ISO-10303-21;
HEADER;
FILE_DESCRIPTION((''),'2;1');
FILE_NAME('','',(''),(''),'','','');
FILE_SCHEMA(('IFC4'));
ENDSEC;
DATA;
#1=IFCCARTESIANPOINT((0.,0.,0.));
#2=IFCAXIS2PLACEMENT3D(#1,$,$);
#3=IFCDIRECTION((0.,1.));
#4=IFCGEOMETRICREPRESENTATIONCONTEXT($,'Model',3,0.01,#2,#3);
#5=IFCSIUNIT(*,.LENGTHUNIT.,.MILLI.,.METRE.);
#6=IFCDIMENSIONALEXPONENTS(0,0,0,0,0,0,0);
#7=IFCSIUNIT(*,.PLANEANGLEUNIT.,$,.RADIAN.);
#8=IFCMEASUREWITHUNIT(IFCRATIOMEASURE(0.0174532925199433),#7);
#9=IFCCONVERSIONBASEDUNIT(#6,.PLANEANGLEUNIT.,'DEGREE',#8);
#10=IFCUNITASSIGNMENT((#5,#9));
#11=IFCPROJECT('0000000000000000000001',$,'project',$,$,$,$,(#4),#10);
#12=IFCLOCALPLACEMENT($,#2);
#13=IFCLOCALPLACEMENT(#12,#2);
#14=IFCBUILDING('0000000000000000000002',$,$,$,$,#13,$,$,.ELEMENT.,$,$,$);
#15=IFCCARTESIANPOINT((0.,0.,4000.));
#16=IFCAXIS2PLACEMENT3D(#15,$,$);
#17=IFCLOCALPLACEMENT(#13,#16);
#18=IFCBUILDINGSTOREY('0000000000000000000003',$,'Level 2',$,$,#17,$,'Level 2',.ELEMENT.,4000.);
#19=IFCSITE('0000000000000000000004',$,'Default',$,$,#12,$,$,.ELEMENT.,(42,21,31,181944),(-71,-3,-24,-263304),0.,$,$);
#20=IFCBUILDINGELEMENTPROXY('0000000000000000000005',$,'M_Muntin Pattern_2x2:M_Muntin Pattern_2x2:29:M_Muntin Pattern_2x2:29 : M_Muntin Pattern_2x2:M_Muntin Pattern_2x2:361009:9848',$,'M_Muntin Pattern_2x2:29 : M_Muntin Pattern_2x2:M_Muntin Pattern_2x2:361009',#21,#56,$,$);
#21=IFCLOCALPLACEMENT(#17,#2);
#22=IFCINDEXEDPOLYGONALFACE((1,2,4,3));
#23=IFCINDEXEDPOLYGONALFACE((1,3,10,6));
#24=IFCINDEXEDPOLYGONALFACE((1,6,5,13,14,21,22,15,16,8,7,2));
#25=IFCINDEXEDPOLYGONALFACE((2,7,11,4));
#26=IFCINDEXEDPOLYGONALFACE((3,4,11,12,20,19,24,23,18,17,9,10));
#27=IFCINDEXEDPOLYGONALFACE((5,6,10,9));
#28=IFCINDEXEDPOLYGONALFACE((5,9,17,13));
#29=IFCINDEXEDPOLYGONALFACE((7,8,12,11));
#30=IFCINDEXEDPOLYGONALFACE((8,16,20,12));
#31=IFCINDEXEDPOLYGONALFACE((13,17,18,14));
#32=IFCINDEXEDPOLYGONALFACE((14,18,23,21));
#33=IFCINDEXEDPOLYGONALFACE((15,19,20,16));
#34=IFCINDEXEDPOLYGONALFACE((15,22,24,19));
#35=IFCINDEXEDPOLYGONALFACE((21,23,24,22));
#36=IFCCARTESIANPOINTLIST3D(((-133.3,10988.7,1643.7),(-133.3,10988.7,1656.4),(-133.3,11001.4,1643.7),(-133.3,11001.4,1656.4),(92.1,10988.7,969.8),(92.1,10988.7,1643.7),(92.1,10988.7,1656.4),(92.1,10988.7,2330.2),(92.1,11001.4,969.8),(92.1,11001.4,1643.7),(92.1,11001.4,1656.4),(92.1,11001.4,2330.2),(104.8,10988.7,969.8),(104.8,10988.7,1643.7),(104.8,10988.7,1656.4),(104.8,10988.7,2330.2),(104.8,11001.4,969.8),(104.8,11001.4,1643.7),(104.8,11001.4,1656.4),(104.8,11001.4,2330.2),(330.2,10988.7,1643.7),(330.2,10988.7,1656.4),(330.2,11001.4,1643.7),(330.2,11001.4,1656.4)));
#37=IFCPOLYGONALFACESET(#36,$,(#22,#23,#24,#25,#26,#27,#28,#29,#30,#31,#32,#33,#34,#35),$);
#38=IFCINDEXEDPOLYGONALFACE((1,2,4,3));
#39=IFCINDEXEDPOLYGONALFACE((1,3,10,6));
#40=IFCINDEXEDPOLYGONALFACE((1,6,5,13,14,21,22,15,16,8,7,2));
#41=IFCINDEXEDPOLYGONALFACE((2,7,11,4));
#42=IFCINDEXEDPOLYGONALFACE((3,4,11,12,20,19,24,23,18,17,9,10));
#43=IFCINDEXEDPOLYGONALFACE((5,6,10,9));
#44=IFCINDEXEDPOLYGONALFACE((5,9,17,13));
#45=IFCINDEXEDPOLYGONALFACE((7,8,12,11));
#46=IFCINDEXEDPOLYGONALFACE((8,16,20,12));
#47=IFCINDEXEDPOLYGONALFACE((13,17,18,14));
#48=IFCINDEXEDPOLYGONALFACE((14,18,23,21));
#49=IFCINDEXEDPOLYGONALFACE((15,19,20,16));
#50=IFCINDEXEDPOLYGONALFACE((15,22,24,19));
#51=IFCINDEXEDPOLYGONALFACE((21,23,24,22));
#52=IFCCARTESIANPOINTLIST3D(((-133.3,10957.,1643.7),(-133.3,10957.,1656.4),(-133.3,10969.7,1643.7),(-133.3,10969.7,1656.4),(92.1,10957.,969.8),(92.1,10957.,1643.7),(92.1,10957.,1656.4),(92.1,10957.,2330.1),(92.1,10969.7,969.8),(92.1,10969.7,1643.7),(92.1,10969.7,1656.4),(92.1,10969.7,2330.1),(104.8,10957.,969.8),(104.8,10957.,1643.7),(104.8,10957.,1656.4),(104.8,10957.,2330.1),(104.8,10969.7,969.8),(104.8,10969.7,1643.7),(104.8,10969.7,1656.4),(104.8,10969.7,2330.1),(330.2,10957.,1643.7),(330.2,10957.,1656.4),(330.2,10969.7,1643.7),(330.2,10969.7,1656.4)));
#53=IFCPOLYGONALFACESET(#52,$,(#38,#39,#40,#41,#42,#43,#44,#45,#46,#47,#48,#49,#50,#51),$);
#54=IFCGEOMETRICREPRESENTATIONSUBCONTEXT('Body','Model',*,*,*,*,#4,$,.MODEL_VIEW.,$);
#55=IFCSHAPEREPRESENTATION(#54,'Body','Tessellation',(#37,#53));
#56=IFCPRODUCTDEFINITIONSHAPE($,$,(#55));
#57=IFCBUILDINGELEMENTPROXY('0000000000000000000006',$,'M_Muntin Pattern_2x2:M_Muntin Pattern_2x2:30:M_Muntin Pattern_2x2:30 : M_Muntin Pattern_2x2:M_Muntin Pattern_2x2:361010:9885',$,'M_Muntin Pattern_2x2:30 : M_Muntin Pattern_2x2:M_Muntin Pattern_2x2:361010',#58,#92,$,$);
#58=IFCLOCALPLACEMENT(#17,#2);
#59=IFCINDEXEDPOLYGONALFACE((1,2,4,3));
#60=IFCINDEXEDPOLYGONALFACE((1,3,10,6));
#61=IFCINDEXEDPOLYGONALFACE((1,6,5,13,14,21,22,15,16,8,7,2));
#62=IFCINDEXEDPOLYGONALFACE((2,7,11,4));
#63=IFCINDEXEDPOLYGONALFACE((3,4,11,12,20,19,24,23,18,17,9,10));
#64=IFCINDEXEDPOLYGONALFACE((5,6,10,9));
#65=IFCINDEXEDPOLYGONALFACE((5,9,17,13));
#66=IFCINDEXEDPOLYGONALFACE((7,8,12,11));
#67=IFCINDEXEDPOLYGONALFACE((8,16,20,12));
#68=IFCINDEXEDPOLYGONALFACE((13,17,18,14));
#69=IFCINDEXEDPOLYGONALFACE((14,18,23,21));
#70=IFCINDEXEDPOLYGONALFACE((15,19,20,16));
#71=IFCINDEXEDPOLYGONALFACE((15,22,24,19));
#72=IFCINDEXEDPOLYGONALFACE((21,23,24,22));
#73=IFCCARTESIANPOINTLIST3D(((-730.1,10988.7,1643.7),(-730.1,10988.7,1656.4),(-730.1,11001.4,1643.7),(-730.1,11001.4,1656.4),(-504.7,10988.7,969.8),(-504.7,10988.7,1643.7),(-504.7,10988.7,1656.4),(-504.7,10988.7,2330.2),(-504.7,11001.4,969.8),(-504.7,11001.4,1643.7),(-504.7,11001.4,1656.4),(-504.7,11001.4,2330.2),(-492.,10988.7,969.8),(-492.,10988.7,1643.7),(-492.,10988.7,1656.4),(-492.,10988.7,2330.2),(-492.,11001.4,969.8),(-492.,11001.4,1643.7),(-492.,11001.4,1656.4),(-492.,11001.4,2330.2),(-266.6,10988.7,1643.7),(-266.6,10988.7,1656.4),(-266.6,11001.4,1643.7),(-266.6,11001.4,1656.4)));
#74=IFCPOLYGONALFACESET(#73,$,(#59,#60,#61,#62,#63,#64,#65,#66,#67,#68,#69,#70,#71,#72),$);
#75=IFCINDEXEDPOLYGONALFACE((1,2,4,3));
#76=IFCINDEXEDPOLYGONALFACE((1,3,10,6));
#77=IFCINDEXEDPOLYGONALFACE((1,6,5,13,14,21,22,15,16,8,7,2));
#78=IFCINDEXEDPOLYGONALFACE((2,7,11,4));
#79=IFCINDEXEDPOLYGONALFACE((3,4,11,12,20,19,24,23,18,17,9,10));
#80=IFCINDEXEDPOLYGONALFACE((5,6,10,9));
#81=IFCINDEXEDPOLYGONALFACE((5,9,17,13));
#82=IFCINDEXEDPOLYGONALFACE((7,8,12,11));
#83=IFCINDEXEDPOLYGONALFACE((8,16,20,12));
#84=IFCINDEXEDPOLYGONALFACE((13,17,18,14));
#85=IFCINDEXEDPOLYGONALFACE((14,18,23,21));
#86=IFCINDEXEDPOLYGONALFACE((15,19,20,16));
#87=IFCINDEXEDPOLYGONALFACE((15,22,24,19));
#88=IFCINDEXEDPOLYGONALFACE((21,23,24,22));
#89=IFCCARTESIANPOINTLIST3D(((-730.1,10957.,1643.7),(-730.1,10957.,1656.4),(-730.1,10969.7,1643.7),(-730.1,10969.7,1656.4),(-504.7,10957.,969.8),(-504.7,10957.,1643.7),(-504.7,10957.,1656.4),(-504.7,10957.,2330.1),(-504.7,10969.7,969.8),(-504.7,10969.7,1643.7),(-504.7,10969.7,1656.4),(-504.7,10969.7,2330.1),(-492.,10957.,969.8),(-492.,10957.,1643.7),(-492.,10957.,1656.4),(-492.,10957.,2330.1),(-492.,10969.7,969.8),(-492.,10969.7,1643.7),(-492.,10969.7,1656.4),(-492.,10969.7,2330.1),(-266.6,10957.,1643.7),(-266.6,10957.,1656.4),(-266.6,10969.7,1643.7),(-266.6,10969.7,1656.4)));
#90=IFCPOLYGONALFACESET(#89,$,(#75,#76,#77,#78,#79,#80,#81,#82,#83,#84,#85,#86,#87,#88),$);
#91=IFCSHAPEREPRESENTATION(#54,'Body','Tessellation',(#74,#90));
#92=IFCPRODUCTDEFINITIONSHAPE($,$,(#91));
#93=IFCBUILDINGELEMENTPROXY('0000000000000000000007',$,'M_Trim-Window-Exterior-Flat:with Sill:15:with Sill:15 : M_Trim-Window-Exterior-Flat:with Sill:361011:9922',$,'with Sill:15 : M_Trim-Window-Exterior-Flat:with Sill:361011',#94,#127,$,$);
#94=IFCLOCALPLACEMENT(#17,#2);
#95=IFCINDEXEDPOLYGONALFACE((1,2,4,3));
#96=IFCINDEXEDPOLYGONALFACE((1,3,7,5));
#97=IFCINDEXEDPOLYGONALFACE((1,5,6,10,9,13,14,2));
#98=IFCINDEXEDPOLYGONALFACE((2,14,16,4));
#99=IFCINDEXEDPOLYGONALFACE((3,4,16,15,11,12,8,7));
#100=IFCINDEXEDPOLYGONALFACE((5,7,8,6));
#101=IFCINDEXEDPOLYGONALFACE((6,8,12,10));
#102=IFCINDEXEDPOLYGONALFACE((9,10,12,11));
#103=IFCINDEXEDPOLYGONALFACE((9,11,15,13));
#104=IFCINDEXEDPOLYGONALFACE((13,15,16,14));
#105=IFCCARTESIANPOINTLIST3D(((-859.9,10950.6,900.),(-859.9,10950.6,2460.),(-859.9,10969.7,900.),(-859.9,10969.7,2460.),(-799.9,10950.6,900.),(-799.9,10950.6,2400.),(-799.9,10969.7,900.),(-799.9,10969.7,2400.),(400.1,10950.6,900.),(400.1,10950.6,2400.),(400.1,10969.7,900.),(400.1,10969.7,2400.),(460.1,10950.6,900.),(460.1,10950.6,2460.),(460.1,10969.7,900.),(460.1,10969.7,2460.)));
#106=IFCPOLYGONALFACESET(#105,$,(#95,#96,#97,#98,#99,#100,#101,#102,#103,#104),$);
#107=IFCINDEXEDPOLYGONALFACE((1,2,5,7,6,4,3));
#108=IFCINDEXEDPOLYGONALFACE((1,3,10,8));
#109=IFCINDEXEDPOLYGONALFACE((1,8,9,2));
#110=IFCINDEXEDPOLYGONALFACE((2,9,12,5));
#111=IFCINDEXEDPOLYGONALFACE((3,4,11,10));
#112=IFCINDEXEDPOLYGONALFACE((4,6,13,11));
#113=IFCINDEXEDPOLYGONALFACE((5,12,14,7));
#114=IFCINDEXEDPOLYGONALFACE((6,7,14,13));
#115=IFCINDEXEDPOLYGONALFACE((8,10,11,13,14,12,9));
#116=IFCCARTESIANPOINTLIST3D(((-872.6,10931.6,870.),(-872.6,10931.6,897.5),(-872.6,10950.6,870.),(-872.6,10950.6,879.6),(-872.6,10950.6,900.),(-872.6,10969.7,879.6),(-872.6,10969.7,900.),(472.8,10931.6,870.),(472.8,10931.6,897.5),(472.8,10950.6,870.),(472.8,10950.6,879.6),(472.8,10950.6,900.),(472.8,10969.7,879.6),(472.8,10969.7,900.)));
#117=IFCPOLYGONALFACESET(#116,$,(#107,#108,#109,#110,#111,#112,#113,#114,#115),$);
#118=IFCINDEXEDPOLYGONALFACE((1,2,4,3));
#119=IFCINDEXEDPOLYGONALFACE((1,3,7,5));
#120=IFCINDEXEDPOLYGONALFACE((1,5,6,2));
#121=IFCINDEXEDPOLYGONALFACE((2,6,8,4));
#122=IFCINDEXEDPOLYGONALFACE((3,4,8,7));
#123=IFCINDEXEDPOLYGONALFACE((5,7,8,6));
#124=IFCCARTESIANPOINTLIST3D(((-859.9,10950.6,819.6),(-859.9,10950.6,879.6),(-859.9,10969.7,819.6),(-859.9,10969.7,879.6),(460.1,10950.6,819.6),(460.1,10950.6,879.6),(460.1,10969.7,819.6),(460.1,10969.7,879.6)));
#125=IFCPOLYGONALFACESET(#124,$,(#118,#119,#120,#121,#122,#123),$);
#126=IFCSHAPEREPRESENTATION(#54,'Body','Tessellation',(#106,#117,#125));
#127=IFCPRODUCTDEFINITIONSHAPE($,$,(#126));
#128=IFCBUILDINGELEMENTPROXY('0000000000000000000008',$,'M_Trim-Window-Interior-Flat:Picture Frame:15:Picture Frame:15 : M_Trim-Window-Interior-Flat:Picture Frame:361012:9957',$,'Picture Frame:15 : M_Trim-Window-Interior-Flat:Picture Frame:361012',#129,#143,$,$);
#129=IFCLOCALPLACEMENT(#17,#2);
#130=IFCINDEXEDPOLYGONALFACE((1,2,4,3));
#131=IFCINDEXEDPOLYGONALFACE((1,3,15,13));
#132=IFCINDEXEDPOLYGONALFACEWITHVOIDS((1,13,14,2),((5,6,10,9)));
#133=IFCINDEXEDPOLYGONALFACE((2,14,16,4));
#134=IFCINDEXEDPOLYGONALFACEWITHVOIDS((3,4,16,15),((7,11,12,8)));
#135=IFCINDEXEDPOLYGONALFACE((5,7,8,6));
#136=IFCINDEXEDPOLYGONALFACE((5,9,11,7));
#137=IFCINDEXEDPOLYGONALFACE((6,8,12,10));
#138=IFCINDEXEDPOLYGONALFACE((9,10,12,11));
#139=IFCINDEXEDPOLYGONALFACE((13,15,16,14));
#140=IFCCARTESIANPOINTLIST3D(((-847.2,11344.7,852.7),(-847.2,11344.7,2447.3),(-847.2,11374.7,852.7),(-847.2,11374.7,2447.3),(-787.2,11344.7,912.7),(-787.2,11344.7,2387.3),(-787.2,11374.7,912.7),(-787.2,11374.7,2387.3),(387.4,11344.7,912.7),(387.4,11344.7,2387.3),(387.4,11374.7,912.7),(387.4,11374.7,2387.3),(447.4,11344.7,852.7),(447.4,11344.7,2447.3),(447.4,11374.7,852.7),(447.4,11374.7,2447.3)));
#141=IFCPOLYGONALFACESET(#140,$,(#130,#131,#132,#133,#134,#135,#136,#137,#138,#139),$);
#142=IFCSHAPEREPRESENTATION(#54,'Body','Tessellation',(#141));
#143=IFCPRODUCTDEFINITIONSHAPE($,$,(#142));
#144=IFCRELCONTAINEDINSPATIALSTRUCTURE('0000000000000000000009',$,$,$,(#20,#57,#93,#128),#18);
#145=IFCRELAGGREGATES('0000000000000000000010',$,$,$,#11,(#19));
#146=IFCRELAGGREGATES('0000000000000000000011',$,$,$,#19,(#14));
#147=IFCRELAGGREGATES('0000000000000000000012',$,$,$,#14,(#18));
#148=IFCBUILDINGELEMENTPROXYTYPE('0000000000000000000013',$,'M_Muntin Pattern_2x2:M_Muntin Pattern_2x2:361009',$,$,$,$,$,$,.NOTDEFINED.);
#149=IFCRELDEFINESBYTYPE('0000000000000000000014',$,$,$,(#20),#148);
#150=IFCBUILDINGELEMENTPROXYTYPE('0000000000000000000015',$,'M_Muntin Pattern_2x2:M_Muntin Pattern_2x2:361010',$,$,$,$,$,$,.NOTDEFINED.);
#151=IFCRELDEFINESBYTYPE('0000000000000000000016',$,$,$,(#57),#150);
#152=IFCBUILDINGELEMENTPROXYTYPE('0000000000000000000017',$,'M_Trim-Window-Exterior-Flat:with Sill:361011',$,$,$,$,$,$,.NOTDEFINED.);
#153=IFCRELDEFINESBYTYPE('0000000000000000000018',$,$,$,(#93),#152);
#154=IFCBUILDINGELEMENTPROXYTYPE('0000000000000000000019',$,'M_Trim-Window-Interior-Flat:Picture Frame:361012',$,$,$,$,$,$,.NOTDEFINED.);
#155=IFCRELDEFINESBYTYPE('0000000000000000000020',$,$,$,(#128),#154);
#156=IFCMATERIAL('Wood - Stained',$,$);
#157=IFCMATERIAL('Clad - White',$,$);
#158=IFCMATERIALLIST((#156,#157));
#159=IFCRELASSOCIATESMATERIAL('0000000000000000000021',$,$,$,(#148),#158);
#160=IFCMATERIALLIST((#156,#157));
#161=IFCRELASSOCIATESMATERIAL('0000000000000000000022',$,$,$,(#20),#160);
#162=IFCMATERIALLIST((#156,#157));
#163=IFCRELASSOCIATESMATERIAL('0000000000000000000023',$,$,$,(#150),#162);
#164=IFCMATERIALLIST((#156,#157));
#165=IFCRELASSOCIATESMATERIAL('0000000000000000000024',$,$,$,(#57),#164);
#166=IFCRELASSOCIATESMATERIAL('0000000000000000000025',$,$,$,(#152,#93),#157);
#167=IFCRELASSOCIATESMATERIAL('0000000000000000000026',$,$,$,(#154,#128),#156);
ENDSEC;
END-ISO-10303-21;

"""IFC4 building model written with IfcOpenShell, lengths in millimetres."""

from ifc_helpers import new_model, entity, si_unit, converted_unit, direction, frame, origin, origin_2d_with_axis, place, context, subcontext, project, spatial, polyline, rectangle, outline, extrude, source, transform, mapped, material, material_list, type_object, type_shapes, element, save


model = new_model("IFC4")

# Units and contexts
model_context = context("Model", 3, precision=0.01, world=origin(), true_north=direction((0.0, 1.0)))
body_context = subcontext(model_context, "Body", "Model", "MODEL_VIEW")
ifc_project = project(units=[si_unit("LENGTHUNIT", "METRE", prefix="MILLI"), converted_unit("PLANEANGLEUNIT", "DEGREE", entity("IfcRatioMeasure", 0.0174532925199433), si_unit("PLANEANGLEUNIT", "RADIAN"), dimensions=[0, 0, 0, 0, 0, 0, 0])], contexts=[model_context])

# Site, building, storey
site_placement = place(None, origin())
site = spatial("IfcSite", under=ifc_project, at=site_placement, Name="Default", CompositionType="ELEMENT", RefLatitude=(42, 21, 31, 181944), RefLongitude=(-71, -3, -24, -263304), RefElevation=0.0)
building_placement = place(site_placement, origin())
building = spatial("IfcBuilding", under=site, at=building_placement, CompositionType="ELEMENT")
storey_placement = place(building_placement, frame((0.0, 0.0, 4000.0)))
storey = spatial("IfcBuildingStorey", under=building, at=storey_placement, Name="Level 2", LongName="Level 2", CompositionType="ELEMENT", Elevation=4000.0)

# Building element proxies
ifc_material_1 = material(Name="Wood - Stained")
ifc_material_2 = material(Name="Clad - White")
ifc_material_list_1 = material_list([ifc_material_1, ifc_material_2])
ifc_material_list_2 = material_list([ifc_material_1, ifc_material_2])
building_element_proxy_type_1 = type_object("IfcBuildingElementProxyType", Name="M_Muntin Pattern_2x2:M_Muntin Pattern_2x2:361009", PredefinedType="NOTDEFINED", material=ifc_material_list_2)
shared_shape_1 = source(origin(), body_context, "Body", "SweptSolid", [
    extrude(outline(polyline([(-680.2, 6.4), (-680.2, -6.3), (-6.4, -6.3), (-6.4, -231.7), (6.3, -231.7), (6.3, -6.3), (680.2, -6.3), (680.2, 6.4), (6.3, 6.4), (6.3, 231.7), (-6.4, 231.7), (-6.4, 6.4), (-680.2, 6.4)])), frame((98.5, 10988.7, 5650.0), z_axis=(0.0, -1.0, 0.0), x_axis=(0.0, 0.0, -1.0)), (0.0, 0.0, -1.0), 12.7),
    extrude(outline(polyline([(-680.1, 6.4), (-680.1, -6.3), (-6.4, -6.3), (-6.4, -231.7), (6.3, -231.7), (6.3, -6.3), (680.2, -6.3), (680.2, 6.4), (6.3, 6.4), (6.3, 231.7), (-6.4, 231.7), (-6.4, 6.4), (-680.1, 6.4)])), frame((98.5, 10957.0, 5650.0), z_axis=(0.0, -1.0, 0.0), x_axis=(0.0, 0.0, -1.0)), (0.0, 0.0, -1.0), 12.7),
])
type_shapes(building_element_proxy_type_1, [shared_shape_1])
proxy_1_placement = place(storey_placement, frame((0.0, 0.0, -4000.0)))
element("IfcBuildingElementProxy", 1, at=proxy_1_placement, inside=storey, type_object=building_element_proxy_type_1, material=ifc_material_list_1, Name="M_Muntin Pattern_2x2:M_Muntin Pattern_2x2:29:M_Muntin Pattern_2x2:29 : M_Muntin Pattern_2x2:M_Muntin Pattern_2x2:361009:9848", ObjectType="M_Muntin Pattern_2x2:29 : M_Muntin Pattern_2x2:M_Muntin Pattern_2x2:361009", context=body_context, shape_type="MappedRepresentation", body=[
    mapped(shared_shape_1, transform((0.0, 0.0, 0.0), scale=1.0)),
])
ifc_material_list_3 = material_list([ifc_material_1, ifc_material_2])
ifc_material_list_4 = material_list([ifc_material_1, ifc_material_2])
building_element_proxy_type_2 = type_object("IfcBuildingElementProxyType", Name="M_Muntin Pattern_2x2:M_Muntin Pattern_2x2:361010", PredefinedType="NOTDEFINED", material=ifc_material_list_4)
shared_shape_2 = source(origin(), body_context, "Body", "SweptSolid", [
    extrude(outline(polyline([(-6.4, -680.1), (6.3, -680.1), (6.3, -6.4), (231.7, -6.4), (231.7, 6.3), (6.3, 6.3), (6.3, 680.2), (-6.4, 680.2), (-6.4, 6.3), (-231.7, 6.3), (-231.7, -6.4), (-6.4, -6.4), (-6.4, -680.1)])), frame((-498.4, 10988.7, 5650.0), z_axis=(0.0, 1.0, 0.0), x_axis=(1.0, 0.0, 0.0)), (0.0, 0.0, 1.0), 12.7),
    extrude(outline(polyline([(-6.4, -680.1), (6.3, -680.1), (6.3, -6.4), (231.7, -6.4), (231.7, 6.3), (6.3, 6.3), (6.3, 680.2), (-6.4, 680.2), (-6.4, 6.3), (-231.7, 6.3), (-231.7, -6.4), (-6.4, -6.4), (-6.4, -680.1)])), frame((-498.4, 10957.0, 5650.0), z_axis=(0.0, 1.0, 0.0), x_axis=(1.0, 0.0, 0.0)), (0.0, 0.0, 1.0), 12.7),
])
type_shapes(building_element_proxy_type_2, [shared_shape_2])
proxy_2_placement = place(storey_placement, frame((0.0, 0.0, -4000.0)))
element("IfcBuildingElementProxy", 2, at=proxy_2_placement, inside=storey, type_object=building_element_proxy_type_2, material=ifc_material_list_3, Name="M_Muntin Pattern_2x2:M_Muntin Pattern_2x2:30:M_Muntin Pattern_2x2:30 : M_Muntin Pattern_2x2:M_Muntin Pattern_2x2:361010:9885", ObjectType="M_Muntin Pattern_2x2:30 : M_Muntin Pattern_2x2:M_Muntin Pattern_2x2:361010", context=body_context, shape_type="MappedRepresentation", body=[
    mapped(shared_shape_2, transform((0.0, 0.0, 0.0), scale=1.0)),
])
building_element_proxy_type_3 = type_object("IfcBuildingElementProxyType", Name="M_Trim-Window-Exterior-Flat:with Sill:361011", PredefinedType="NOTDEFINED", material=ifc_material_2)
shared_shape_3 = source(origin(), body_context, "Body", "SweptSolid", [
    extrude(outline(polyline([(-765.0, -660.0), (795.0, -660.0), (795.0, 660.0), (-765.0, 660.0), (-765.0, 600.0), (735.0, 600.0), (735.0, -600.0), (-765.0, -600.0), (-765.0, -660.0)])), frame((-199.9, 10950.6, 5665.0), z_axis=(0.0, 1.0, 0.0), x_axis=(0.0, 0.0, 1.0)), (0.0, 0.0, 1.0), 19.1),
    extrude(outline(polyline([(-15.2, 0.0), (-15.2, -19.0), (12.3, -19.0), (14.8, 0.0), (14.8, 19.0), (-5.7, 19.0), (-5.7, 0.0), (-15.2, 0.0)])), frame((-872.6, 10950.6, 4885.2), z_axis=(-1.0, 0.0, 0.0), x_axis=(0.0, 0.0, 1.0)), (0.0, 0.0, -1.0), 1345.4),
    extrude(rectangle(XDim=19.1, YDim=1320.0, at=origin_2d_with_axis()), frame((-199.9, 10960.1, 4819.6), z_axis=(0.0, 0.0, 1.0), x_axis=(0.0, 1.0, 0.0)), (0.0, 0.0, 1.0), 60.0),
])
type_shapes(building_element_proxy_type_3, [shared_shape_3])
proxy_3_placement = place(storey_placement, frame((0.0, 0.0, -4000.0)))
element("IfcBuildingElementProxy", 3, at=proxy_3_placement, inside=storey, type_object=building_element_proxy_type_3, material=ifc_material_2, Name="M_Trim-Window-Exterior-Flat:with Sill:15:with Sill:15 : M_Trim-Window-Exterior-Flat:with Sill:361011:9922", ObjectType="with Sill:15 : M_Trim-Window-Exterior-Flat:with Sill:361011", context=body_context, shape_type="MappedRepresentation", body=[
    mapped(shared_shape_3, transform((0.0, 0.0, 0.0), scale=1.0)),
])
building_element_proxy_type_4 = type_object("IfcBuildingElementProxyType", Name="M_Trim-Window-Interior-Flat:Picture Frame:361012", PredefinedType="NOTDEFINED", material=ifc_material_1)
shared_shape_4 = source(origin(), body_context, "Body", "SweptSolid", [
    extrude(outline(polyline([(-797.3, -647.3), (797.3, -647.3), (797.3, 647.3), (-797.3, 647.3), (-797.3, -647.3)]), holes=[polyline([(737.3, 587.3), (737.3, -587.3), (-737.3, -587.3), (-737.3, 587.3), (737.3, 587.3)])]), frame((-199.9, 11344.7, 5650.0), z_axis=(0.0, 1.0, 0.0), x_axis=(0.0, 0.0, -1.0)), (0.0, 0.0, 1.0), 30.0),
])
type_shapes(building_element_proxy_type_4, [shared_shape_4])
proxy_4_placement = place(storey_placement, frame((0.0, 0.0, -4000.0)))
element("IfcBuildingElementProxy", 4, at=proxy_4_placement, inside=storey, type_object=building_element_proxy_type_4, material=ifc_material_1, Name="M_Trim-Window-Interior-Flat:Picture Frame:15:Picture Frame:15 : M_Trim-Window-Interior-Flat:Picture Frame:361012:9957", ObjectType="Picture Frame:15 : M_Trim-Window-Interior-Flat:Picture Frame:361012", context=body_context, shape_type="MappedRepresentation", body=[
    mapped(shared_shape_4, transform((0.0, 0.0, 0.0), scale=1.0)),
])

save(model, "model.ifc")
